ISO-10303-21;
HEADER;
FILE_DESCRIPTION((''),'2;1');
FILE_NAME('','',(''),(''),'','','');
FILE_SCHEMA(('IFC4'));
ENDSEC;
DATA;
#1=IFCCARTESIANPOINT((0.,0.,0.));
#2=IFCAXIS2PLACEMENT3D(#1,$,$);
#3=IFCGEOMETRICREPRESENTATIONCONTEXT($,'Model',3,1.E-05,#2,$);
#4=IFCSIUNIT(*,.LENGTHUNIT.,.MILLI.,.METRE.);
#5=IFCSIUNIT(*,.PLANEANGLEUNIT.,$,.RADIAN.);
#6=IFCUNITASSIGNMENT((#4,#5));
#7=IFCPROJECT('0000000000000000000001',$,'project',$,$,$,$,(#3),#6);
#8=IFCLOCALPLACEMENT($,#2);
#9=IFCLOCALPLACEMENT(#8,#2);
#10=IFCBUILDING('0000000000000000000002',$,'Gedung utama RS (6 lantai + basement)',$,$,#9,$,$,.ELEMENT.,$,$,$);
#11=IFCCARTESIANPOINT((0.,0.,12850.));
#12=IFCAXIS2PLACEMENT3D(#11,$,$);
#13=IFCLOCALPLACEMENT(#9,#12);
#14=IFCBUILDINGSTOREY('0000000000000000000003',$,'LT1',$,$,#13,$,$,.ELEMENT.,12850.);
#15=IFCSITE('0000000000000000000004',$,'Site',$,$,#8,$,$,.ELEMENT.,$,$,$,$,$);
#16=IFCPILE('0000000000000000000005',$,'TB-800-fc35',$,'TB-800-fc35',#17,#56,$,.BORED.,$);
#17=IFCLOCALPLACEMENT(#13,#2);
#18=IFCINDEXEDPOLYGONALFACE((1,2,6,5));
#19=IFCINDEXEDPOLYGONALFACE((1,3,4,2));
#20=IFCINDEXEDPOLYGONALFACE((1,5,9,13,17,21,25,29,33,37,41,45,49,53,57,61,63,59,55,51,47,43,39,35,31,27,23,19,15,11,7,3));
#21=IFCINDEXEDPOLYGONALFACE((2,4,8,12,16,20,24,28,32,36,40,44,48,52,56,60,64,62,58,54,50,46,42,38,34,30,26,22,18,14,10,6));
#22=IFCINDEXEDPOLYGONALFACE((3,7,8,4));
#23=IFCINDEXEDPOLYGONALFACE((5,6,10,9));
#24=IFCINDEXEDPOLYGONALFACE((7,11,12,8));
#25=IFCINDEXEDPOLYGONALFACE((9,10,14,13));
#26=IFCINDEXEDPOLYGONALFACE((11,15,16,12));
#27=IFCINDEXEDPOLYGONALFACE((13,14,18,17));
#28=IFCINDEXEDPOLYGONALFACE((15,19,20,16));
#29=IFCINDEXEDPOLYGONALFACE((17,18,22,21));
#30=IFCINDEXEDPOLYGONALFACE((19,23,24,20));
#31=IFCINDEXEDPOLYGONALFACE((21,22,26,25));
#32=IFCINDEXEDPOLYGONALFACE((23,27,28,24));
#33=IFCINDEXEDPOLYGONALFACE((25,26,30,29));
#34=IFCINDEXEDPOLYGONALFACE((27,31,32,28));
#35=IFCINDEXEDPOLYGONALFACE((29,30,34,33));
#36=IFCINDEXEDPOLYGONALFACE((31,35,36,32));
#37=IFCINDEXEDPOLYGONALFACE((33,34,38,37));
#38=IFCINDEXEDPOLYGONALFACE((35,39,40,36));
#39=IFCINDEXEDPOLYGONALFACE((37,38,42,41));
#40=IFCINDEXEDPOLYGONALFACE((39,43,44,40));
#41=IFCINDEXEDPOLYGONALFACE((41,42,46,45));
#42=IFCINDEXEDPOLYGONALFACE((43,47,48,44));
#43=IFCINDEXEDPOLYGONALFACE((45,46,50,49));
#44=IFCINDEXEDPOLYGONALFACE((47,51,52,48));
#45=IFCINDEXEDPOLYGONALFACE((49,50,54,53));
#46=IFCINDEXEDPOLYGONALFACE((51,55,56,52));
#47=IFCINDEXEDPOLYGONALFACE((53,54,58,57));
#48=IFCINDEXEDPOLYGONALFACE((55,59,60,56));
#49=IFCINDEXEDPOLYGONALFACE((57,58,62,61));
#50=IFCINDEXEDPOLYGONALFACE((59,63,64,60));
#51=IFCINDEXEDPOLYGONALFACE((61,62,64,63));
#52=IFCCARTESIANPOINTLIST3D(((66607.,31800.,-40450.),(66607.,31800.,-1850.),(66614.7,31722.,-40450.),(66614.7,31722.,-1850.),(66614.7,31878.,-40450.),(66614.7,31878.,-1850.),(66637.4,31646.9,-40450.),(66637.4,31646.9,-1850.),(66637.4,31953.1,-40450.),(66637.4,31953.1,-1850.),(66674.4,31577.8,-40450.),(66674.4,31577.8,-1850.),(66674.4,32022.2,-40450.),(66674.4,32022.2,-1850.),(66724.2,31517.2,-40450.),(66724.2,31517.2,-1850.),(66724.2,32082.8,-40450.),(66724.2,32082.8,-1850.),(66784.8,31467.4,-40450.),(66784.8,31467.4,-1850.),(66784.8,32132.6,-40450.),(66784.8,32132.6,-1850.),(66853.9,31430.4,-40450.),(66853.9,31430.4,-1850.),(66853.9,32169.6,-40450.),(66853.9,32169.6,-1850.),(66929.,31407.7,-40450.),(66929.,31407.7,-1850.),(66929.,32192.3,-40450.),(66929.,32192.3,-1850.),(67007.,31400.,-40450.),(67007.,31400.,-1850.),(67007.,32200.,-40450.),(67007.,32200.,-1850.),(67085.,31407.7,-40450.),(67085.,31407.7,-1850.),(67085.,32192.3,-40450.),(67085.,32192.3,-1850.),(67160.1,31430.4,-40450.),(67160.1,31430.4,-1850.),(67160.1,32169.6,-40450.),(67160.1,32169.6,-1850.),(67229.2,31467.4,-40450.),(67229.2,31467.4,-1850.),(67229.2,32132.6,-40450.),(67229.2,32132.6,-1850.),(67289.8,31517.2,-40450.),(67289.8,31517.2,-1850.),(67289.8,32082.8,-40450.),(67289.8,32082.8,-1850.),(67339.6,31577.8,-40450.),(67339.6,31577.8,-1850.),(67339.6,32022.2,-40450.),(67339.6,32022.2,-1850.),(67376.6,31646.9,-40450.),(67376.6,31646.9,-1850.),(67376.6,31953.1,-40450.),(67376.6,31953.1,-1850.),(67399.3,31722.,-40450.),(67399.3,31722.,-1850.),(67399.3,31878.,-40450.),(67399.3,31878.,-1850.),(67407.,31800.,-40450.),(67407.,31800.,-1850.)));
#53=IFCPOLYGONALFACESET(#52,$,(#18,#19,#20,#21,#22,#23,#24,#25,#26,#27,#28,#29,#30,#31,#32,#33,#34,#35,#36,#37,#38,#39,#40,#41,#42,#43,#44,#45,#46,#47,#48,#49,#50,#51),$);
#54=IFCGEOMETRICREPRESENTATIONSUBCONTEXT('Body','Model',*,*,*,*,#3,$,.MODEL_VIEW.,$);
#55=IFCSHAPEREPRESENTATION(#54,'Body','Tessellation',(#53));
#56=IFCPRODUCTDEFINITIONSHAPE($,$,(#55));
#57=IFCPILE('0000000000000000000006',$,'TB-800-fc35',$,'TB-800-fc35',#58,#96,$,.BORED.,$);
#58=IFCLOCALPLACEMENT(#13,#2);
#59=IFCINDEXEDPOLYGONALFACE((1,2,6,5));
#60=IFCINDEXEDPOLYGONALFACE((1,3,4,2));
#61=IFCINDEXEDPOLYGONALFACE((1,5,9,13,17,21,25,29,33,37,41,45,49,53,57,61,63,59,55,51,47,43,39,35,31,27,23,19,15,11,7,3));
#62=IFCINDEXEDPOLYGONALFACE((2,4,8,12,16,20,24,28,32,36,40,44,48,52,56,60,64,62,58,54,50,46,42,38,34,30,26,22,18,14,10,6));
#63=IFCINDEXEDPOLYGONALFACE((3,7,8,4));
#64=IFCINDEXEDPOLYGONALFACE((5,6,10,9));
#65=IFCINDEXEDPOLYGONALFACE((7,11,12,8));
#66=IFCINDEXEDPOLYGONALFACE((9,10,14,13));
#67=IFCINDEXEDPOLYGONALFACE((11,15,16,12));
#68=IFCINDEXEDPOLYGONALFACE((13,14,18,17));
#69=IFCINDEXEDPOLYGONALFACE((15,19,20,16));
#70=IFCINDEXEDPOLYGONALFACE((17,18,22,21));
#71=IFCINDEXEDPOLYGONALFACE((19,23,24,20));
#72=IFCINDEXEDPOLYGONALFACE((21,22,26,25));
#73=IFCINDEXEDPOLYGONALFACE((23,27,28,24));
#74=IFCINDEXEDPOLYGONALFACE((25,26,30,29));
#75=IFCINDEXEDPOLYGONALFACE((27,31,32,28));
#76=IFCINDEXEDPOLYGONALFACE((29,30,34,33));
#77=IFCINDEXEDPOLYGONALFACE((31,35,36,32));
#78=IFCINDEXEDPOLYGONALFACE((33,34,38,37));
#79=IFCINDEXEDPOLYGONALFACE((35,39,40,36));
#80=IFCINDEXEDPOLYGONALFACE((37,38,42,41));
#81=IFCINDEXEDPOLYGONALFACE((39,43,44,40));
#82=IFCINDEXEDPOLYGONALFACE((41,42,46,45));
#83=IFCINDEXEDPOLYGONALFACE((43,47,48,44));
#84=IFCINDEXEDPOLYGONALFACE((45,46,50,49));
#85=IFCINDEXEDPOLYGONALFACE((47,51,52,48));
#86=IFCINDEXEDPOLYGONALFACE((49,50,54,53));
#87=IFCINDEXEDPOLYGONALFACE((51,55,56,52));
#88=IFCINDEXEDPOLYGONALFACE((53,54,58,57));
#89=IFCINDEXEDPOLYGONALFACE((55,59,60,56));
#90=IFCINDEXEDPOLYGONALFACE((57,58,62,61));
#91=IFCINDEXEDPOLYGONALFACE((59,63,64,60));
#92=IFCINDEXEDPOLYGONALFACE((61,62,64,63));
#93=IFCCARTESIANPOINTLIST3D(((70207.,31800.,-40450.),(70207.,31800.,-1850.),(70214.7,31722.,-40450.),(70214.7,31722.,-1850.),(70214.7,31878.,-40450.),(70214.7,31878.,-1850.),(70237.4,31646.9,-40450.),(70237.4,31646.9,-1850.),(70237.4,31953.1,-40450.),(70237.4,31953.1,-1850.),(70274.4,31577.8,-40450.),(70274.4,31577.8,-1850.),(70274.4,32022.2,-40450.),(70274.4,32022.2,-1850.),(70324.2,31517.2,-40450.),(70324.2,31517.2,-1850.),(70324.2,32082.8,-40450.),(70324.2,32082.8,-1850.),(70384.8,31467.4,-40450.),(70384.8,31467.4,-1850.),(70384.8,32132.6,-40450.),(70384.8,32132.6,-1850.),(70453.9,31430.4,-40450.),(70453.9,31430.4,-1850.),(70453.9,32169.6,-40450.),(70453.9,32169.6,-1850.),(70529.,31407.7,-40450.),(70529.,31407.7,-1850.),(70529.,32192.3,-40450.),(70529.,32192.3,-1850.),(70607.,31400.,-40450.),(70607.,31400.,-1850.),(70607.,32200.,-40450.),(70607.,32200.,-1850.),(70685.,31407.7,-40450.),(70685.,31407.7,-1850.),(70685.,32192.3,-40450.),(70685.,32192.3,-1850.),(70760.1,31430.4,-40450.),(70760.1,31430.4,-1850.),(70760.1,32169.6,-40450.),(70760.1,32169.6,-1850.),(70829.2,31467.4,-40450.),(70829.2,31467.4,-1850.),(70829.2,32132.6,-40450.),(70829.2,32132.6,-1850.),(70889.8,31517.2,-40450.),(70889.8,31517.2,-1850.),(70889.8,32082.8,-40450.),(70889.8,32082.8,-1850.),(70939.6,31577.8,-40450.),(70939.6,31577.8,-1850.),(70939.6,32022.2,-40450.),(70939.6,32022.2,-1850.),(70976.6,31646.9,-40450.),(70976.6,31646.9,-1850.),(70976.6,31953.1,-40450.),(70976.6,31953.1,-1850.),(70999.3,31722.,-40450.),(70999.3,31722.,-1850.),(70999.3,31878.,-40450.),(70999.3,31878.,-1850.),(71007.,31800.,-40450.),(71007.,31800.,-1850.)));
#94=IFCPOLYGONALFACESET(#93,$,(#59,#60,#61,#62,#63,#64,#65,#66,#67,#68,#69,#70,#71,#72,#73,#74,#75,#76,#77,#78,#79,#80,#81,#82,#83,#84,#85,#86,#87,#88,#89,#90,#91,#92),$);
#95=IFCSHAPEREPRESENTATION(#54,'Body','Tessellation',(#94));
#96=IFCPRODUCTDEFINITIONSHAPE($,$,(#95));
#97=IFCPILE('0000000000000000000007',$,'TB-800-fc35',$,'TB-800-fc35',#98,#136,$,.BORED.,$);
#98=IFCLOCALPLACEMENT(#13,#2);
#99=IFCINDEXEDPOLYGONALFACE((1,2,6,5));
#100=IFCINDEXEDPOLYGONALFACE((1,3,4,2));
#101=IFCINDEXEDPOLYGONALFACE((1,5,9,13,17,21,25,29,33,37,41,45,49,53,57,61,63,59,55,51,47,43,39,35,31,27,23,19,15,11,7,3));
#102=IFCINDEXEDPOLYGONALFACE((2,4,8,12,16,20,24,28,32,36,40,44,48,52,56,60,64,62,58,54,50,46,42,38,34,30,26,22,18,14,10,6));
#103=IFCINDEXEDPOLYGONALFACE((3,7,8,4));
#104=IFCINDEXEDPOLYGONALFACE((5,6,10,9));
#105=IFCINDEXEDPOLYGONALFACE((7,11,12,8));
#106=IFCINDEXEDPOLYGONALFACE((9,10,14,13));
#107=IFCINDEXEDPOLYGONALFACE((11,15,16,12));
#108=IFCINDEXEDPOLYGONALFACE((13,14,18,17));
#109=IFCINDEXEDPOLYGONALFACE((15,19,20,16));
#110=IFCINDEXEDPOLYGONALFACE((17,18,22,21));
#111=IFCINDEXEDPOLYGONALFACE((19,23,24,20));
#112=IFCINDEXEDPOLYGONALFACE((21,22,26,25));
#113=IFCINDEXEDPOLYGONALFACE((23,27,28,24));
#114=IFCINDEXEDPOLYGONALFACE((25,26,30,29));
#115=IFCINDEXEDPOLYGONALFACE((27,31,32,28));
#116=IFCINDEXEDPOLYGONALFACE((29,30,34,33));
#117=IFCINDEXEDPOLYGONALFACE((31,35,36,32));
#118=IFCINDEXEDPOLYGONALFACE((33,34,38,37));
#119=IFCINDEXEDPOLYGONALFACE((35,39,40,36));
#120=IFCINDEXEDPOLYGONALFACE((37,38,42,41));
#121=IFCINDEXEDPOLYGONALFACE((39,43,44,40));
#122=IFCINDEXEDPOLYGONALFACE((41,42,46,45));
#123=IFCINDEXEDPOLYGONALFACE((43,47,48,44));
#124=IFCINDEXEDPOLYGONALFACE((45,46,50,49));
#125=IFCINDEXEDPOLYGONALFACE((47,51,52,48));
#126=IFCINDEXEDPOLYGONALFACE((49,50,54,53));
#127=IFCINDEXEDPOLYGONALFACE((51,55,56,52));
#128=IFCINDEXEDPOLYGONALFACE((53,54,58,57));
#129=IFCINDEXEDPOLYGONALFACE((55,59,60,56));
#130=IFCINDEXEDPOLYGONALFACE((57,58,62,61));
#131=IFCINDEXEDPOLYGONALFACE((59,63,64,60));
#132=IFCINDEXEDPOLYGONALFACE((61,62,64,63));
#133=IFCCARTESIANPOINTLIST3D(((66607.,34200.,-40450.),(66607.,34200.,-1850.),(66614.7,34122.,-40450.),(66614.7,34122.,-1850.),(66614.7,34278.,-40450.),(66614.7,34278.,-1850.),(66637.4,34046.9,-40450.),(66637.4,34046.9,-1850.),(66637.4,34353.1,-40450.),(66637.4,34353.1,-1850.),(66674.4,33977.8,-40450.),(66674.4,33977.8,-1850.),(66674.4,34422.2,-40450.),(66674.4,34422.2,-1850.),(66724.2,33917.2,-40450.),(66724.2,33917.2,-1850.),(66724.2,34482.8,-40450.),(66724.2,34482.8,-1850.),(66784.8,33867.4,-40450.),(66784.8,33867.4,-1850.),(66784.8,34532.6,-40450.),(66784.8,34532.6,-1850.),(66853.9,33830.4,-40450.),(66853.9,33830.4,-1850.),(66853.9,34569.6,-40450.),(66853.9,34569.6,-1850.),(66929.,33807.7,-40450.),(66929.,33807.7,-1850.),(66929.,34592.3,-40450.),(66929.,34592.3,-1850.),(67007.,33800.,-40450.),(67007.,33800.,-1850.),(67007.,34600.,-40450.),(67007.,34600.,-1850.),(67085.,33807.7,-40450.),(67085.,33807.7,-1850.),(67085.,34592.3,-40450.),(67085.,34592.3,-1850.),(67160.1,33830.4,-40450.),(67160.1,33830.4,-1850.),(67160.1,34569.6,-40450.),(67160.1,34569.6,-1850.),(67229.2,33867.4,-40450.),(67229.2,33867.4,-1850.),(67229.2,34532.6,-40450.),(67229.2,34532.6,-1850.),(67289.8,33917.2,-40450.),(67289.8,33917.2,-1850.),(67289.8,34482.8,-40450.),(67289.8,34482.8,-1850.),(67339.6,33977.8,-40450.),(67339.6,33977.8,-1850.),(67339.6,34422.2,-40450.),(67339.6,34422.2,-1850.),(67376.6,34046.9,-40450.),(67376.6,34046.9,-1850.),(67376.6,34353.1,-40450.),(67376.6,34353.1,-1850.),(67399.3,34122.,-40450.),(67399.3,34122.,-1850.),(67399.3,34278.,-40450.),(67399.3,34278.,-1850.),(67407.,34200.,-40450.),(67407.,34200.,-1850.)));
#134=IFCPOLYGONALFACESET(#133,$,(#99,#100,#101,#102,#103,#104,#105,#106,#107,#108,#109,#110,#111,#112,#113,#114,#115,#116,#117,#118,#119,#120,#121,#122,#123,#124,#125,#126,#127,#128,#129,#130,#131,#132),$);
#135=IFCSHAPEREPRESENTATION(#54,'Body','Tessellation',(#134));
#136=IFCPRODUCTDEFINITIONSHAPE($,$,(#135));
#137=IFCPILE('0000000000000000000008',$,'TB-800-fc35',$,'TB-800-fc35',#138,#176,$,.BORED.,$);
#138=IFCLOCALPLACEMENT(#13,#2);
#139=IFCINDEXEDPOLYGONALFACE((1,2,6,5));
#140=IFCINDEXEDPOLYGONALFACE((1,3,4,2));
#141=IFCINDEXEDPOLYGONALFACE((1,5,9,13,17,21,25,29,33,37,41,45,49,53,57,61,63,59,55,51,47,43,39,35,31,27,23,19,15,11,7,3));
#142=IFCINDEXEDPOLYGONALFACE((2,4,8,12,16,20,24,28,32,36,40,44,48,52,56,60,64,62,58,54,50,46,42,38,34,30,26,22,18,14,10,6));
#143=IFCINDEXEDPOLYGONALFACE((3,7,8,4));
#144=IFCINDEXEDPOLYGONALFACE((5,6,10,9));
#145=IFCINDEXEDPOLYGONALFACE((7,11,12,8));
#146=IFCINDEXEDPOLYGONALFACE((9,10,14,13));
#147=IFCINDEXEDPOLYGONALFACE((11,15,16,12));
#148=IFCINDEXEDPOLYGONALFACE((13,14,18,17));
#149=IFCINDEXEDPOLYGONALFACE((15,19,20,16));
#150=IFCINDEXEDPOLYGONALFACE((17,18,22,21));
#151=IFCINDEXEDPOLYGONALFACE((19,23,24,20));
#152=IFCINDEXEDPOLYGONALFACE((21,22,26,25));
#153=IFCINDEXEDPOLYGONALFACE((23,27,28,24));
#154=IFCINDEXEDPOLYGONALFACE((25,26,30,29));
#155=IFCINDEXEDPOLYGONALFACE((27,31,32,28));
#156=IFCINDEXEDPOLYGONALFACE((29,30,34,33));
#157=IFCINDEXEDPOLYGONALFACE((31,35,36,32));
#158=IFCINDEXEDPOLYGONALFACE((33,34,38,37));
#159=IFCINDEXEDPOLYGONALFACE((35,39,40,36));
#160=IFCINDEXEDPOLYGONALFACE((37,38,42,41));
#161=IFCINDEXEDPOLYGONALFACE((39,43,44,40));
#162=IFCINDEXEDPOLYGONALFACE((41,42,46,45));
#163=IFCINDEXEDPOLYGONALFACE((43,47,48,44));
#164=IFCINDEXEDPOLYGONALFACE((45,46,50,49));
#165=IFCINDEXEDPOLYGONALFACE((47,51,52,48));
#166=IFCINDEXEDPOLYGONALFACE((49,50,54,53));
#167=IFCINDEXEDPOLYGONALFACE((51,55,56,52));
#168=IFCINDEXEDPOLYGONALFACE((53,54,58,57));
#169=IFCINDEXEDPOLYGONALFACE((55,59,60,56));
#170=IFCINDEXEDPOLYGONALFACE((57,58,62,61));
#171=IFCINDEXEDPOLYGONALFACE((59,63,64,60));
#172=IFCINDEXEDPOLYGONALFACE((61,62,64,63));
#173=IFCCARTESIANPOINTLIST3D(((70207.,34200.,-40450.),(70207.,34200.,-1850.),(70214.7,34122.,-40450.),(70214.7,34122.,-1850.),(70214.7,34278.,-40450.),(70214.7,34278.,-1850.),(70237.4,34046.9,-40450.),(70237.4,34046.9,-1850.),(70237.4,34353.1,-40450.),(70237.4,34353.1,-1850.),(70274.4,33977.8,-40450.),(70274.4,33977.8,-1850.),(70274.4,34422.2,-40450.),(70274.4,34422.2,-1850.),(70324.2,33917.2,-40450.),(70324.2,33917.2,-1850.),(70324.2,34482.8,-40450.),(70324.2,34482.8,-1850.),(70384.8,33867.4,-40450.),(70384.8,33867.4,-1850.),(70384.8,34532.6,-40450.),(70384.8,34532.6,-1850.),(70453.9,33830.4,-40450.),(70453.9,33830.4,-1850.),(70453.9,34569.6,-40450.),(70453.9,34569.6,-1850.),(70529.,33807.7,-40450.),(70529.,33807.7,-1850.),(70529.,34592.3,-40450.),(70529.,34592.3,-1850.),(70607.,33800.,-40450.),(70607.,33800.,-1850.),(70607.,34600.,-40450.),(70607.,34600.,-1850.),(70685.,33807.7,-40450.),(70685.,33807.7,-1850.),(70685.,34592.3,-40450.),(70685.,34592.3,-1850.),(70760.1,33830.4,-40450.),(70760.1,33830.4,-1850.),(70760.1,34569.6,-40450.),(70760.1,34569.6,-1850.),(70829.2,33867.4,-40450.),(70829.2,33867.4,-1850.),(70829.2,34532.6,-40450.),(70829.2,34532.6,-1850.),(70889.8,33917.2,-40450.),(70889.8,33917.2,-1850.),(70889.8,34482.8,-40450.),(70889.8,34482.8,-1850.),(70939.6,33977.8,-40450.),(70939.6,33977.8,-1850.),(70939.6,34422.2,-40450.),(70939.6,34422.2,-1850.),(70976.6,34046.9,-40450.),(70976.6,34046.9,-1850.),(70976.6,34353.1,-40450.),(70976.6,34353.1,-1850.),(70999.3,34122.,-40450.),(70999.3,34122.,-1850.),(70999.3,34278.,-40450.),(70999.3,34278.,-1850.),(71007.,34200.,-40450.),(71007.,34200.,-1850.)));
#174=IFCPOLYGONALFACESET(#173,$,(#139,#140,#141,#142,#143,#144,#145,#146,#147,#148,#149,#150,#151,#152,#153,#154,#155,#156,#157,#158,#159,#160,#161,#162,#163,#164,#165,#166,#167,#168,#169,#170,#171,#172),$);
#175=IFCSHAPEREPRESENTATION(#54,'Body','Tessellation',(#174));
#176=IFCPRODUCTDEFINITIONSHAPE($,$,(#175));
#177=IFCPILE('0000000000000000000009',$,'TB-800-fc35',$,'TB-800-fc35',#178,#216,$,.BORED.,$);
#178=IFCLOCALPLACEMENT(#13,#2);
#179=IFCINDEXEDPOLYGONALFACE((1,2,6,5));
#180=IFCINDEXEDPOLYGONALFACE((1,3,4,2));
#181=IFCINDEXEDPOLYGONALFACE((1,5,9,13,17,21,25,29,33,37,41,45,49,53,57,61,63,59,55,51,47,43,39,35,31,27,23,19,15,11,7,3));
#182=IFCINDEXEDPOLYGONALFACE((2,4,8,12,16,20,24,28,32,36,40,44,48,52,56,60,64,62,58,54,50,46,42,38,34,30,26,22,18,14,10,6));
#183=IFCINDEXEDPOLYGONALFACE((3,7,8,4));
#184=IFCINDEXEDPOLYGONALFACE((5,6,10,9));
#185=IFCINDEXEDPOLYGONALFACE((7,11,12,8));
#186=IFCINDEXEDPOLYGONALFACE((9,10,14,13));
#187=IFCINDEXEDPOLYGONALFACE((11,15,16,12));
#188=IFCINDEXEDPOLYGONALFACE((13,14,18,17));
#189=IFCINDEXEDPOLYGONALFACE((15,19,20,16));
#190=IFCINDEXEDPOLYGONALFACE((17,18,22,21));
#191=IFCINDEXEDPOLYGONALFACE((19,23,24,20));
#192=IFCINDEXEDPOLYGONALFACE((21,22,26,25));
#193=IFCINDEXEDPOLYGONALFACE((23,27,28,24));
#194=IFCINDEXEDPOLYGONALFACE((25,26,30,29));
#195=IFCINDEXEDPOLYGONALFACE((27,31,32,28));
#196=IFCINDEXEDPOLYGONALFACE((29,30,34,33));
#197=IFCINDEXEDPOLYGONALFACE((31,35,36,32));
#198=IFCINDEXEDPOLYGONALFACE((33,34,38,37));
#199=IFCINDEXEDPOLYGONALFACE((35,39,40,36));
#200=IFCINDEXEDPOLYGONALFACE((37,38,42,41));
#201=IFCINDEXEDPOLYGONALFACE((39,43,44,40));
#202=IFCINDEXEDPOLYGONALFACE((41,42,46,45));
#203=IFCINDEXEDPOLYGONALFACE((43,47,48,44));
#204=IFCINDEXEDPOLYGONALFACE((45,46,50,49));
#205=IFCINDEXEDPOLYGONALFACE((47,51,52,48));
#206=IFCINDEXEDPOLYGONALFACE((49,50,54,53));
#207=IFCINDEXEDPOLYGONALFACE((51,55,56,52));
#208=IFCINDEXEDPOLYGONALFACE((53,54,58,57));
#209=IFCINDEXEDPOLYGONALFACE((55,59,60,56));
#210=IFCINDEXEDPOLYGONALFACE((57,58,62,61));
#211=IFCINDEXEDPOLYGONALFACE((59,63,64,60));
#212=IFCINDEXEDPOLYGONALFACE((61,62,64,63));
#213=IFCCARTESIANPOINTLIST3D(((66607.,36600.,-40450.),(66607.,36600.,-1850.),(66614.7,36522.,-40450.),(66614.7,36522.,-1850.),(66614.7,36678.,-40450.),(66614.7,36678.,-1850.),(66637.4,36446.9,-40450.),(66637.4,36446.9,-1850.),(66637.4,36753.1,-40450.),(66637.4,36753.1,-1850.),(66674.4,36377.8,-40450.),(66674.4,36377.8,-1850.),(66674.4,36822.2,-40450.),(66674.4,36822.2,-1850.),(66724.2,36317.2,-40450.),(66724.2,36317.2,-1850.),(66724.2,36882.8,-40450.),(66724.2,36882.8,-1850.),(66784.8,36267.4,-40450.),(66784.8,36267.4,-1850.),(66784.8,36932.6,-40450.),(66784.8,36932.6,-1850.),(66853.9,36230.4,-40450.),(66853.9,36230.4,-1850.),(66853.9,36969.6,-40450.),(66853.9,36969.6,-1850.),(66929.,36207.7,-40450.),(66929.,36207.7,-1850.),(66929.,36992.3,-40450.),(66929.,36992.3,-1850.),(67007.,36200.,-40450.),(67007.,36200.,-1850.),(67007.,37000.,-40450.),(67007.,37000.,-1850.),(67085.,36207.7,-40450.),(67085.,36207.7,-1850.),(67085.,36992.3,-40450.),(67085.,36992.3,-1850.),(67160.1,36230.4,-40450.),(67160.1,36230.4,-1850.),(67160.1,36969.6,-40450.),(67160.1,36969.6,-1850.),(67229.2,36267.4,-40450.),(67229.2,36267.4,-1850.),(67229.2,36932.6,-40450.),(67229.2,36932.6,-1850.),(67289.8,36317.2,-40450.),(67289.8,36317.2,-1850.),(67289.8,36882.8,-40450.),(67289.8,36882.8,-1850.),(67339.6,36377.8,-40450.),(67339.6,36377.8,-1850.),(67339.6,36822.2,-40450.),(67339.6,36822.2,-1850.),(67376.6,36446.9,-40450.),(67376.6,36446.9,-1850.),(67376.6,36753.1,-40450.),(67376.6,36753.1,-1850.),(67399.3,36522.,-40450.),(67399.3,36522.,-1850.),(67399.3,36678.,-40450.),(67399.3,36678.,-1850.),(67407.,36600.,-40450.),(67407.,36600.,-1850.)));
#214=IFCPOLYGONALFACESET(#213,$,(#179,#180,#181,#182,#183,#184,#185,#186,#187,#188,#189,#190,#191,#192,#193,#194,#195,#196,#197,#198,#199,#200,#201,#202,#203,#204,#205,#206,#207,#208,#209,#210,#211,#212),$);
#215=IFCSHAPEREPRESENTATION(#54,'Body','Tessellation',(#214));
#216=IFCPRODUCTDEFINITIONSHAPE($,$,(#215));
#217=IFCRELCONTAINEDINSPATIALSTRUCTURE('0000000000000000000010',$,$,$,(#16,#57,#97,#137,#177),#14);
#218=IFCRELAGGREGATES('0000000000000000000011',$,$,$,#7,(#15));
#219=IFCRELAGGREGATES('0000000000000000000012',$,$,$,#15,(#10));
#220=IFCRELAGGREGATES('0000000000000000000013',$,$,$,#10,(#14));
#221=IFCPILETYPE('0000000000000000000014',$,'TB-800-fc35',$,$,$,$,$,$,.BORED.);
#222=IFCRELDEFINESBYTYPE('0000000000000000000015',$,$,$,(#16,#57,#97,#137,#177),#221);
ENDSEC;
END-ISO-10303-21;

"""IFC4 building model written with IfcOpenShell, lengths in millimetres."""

from ifc_helpers import new_model, si_unit, frame, origin, origin_2d, place, context, subcontext, project, spatial, circle, extrude, material_profile, profile_set, profile_usage, type_object, element, save


model = new_model("IFC4")

# Units and contexts
model_context = context("Model", 3, precision=1e-05, world=origin())
body_context = subcontext(model_context, "Body", "Model", "MODEL_VIEW")
ifc_project = project(units=[si_unit("LENGTHUNIT", "METRE", prefix="MILLI"), si_unit("PLANEANGLEUNIT", "RADIAN")], contexts=[model_context])

# Site, building, storey
site_placement = place(None, origin())
site = spatial("IfcSite", under=ifc_project, at=site_placement, Name="Site", CompositionType="ELEMENT")
building_placement = place(site_placement, origin())
building = spatial("IfcBuilding", under=site, at=building_placement, Name="Gedung utama RS (6 lantai + basement)", CompositionType="ELEMENT")
storey_placement = place(building_placement, frame((0.0, 0.0, 12850.0)))
storey = spatial("IfcBuildingStorey", under=building, at=storey_placement, Name="LT1", CompositionType="ELEMENT", Elevation=12850.0)

# Piles
ifc_material_profile = material_profile(None, circle(Radius=400.0, at=origin_2d()), Name="TB-800-fc35")
ifc_profile_set = profile_set([ifc_material_profile], Name="TB-800-fc35")
ifc_profile_usage = profile_usage(ifc_profile_set, cardinal=5)
pile_type = type_object("IfcPileType", Name="TB-800-fc35", PredefinedType="BORED", material=ifc_profile_set)
for number, where, z_axis, x_axis, name in (
    (1, (67007.0, 31800.0, -40450.0), (0.0, 0.0, 1.0), (1.0, 0.0, 0.0), "TB-800-fc35"),
    (2, (70607.0, 31800.0, -40450.0), (0.0, 0.0, 1.0), (1.0, 0.0, 0.0), "TB-800-fc35"),
    (3, (67007.0, 34200.0, -40450.0), (0.0, 0.0, 1.0), (1.0, 0.0, 0.0), "TB-800-fc35"),
    (4, (70607.0, 34200.0, -40450.0), (0.0, 0.0, 1.0), (1.0, 0.0, 0.0), "TB-800-fc35"),
    (5, (67007.0, 36600.0, -40450.0), (0.0, 0.0, 1.0), (1.0, 0.0, 0.0), "TB-800-fc35"),
):
    element("IfcPile", number, at=place(storey_placement, frame(where, z_axis=z_axis, x_axis=x_axis)), inside=storey, type_object=pile_type, material=ifc_profile_usage, Name=name, ObjectType="TB-800-fc35", PredefinedType="BORED", context=body_context, shape_type="SweptSolid", body=[
        extrude(circle(Radius=400.0, at=origin_2d()), origin(), (0.0, 0.0, 1.0), 38600.0),
    ])

save(model, "model.ifc")
